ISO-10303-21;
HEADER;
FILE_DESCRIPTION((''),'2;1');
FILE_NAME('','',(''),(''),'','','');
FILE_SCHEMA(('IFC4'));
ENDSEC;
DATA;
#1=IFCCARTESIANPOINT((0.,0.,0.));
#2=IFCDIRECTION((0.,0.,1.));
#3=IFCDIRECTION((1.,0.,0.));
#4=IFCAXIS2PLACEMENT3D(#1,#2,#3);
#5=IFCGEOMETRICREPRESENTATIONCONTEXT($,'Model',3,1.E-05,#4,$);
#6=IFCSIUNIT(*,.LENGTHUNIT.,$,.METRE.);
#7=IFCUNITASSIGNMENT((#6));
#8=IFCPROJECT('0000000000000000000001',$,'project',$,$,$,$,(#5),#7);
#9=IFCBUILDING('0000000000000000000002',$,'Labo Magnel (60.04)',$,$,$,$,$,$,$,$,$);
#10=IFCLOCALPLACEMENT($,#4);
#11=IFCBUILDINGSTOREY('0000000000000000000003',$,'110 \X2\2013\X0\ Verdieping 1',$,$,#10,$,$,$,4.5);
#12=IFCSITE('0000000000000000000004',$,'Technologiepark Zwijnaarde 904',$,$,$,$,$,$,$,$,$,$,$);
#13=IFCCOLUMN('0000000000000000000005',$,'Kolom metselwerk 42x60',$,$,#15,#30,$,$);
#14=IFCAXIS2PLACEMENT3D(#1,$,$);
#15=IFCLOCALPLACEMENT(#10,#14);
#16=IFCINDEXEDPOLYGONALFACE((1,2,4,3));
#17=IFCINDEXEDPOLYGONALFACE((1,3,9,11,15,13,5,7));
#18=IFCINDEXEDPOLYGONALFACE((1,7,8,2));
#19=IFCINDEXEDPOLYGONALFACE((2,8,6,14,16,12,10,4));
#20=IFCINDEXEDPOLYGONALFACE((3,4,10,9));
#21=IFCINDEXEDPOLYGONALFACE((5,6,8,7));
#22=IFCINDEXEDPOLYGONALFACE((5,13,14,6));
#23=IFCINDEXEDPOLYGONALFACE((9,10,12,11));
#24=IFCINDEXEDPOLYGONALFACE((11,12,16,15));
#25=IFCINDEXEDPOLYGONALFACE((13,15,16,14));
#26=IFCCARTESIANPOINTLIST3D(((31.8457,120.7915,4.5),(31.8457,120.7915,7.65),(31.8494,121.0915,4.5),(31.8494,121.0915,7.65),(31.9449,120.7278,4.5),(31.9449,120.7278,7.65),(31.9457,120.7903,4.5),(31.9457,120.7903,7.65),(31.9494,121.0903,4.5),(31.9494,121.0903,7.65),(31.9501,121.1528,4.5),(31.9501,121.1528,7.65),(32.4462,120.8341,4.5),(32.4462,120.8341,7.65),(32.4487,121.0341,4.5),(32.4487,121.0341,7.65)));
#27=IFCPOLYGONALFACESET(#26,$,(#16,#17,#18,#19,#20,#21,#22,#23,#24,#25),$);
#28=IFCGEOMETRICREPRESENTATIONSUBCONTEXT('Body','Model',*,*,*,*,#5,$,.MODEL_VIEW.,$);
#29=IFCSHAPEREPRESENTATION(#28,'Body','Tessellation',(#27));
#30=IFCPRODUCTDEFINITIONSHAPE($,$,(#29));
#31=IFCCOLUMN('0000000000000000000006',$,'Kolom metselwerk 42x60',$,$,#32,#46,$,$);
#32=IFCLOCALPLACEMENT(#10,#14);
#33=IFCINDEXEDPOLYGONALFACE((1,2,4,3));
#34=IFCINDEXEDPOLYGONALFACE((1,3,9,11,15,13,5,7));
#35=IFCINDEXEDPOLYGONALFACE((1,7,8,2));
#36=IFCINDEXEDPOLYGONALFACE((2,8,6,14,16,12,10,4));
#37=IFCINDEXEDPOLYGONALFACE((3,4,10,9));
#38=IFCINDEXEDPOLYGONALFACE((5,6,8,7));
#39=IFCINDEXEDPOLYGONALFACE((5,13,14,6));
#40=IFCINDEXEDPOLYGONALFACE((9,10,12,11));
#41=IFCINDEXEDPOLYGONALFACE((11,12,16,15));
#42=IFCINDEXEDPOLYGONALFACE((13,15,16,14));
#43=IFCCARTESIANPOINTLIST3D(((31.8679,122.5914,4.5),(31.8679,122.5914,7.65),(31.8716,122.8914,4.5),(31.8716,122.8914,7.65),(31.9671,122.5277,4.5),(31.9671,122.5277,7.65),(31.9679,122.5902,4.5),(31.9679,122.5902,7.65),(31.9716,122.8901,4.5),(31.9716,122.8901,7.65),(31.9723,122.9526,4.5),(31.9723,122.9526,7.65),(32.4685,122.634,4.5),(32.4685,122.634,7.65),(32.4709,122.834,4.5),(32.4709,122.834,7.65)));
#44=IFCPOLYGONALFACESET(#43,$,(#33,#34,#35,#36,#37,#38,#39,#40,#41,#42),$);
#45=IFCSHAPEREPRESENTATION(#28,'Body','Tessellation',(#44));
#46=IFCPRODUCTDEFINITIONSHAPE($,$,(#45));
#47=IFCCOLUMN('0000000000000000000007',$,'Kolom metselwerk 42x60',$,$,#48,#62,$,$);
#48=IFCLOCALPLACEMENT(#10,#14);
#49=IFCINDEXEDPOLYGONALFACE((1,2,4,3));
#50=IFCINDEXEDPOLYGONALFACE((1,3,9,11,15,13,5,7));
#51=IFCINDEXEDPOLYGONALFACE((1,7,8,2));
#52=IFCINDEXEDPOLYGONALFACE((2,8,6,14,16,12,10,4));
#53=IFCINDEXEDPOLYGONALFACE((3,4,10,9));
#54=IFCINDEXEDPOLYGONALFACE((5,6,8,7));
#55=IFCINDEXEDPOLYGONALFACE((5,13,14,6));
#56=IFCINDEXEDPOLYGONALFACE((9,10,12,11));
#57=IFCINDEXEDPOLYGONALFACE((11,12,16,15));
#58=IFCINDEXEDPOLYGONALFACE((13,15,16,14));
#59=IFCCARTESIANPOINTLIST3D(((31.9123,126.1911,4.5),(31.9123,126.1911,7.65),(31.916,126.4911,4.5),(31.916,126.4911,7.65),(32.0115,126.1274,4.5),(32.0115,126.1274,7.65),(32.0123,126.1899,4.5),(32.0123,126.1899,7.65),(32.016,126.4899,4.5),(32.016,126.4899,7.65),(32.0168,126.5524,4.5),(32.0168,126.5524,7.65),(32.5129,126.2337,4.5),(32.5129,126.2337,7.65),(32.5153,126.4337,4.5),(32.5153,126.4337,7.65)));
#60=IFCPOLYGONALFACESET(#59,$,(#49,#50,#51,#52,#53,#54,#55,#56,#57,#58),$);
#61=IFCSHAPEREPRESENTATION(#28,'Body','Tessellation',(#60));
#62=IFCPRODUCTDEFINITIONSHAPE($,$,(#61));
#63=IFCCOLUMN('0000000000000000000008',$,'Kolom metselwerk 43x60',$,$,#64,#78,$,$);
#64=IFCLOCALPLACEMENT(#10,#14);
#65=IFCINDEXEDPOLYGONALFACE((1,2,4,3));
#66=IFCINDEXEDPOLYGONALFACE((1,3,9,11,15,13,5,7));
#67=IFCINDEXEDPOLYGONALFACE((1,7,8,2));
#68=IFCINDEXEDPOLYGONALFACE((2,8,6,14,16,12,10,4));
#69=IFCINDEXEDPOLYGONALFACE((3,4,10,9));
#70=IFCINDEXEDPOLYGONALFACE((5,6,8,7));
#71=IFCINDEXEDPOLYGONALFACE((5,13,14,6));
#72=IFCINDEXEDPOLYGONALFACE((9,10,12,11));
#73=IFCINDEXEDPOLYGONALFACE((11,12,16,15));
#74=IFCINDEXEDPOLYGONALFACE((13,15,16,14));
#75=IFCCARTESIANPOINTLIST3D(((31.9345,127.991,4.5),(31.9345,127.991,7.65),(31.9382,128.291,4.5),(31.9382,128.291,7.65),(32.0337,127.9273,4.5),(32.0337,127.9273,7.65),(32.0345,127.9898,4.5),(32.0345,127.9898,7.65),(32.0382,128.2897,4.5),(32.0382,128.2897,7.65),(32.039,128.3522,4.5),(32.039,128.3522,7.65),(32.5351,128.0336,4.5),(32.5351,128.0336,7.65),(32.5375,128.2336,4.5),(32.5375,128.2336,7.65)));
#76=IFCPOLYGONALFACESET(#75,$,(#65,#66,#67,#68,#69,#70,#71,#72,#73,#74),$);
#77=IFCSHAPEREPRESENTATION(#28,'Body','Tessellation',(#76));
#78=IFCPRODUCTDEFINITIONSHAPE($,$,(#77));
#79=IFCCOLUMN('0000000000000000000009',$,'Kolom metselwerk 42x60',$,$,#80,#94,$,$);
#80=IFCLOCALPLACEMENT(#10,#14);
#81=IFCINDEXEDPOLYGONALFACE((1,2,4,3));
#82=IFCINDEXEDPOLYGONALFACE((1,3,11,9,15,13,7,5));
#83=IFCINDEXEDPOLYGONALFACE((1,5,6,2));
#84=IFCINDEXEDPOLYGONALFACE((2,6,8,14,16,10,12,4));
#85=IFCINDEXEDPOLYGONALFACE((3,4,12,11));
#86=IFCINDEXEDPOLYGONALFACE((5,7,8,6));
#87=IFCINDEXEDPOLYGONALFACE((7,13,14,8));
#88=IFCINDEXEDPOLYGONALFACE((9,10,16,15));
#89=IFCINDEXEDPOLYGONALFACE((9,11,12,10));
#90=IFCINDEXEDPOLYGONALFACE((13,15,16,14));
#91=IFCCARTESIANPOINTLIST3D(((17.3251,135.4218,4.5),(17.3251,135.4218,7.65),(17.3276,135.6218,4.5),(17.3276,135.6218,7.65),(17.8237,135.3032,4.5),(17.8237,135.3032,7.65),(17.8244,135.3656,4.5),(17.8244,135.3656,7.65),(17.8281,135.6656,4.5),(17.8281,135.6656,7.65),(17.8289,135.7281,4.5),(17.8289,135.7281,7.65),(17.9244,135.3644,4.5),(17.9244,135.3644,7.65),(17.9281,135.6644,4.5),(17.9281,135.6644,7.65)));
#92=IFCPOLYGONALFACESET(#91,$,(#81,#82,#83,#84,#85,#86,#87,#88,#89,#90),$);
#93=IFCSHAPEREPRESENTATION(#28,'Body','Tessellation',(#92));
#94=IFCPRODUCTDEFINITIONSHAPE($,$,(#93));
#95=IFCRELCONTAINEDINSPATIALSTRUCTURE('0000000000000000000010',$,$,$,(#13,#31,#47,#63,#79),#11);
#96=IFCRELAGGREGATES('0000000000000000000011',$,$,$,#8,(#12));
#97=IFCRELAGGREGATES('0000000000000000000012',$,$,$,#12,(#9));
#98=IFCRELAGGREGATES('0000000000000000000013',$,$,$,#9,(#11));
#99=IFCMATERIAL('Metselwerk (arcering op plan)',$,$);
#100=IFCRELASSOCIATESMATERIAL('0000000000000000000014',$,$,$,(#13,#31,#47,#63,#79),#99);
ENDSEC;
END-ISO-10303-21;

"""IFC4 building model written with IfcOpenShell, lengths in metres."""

from ifc_helpers import new_model, si_unit, frame, origin, origin_with_axes, place, context, subcontext, project, spatial, polyline, outline, extrude, material, element, save


model = new_model("IFC4")

# Units and contexts
model_context = context("Model", 3, precision=1e-05, world=origin_with_axes())
body_context = subcontext(model_context, "Body", "Model", "MODEL_VIEW")
ifc_project = project(units=[si_unit("LENGTHUNIT", "METRE")], contexts=[model_context])

# Site, building, storey
site = spatial("IfcSite", under=ifc_project, Name="Technologiepark Zwijnaarde 904")
building = spatial("IfcBuilding", under=site, Name="Labo Magnel (60.04)")
storey_placement = place(None, origin_with_axes())
storey = spatial("IfcBuildingStorey", under=building, at=storey_placement, Name="110 – Verdieping 1", Elevation=4.5)

# Columns
ifc_material_1 = material(Name="Metselwerk (arcering op plan)")
column_1_placement = place(storey_placement, frame((0.0, 0.0, 4.5), z_axis=(0.0, 0.0, 1.0), x_axis=(1.0, 0.0, 0.0)))
element("IfcColumn", 1, at=column_1_placement, inside=storey, material=ifc_material_1, Name="Kolom metselwerk 42x60", context=body_context, shape_type="SweptSolid", body=[
    extrude(outline(polyline([(32.4487, 121.0341), (31.9501, 121.1528), (31.9494, 121.0903), (31.8494, 121.0915), (31.8457, 120.7915), (31.9457, 120.7903), (31.9449, 120.7278), (32.4462, 120.8341), (32.4487, 121.0341)])), origin(), (0.0, 0.0, 1.0), 3.15),
])
column_2_placement = place(storey_placement, frame((0.0, 0.0, 4.5), z_axis=(0.0, 0.0, 1.0), x_axis=(1.0, 0.0, 0.0)))
element("IfcColumn", 2, at=column_2_placement, inside=storey, material=ifc_material_1, Name="Kolom metselwerk 42x60", context=body_context, shape_type="SweptSolid", body=[
    extrude(outline(polyline([(32.4709, 122.834), (31.9723, 122.9526), (31.9716, 122.8901), (31.8716, 122.8914), (31.8679, 122.5914), (31.9679, 122.5902), (31.9671, 122.5277), (32.4685, 122.634), (32.4709, 122.834)])), origin(), (0.0, 0.0, 1.0), 3.15),
])
column_3_placement = place(storey_placement, frame((0.0, 0.0, 4.5), z_axis=(0.0, 0.0, 1.0), x_axis=(1.0, 0.0, 0.0)))
element("IfcColumn", 3, at=column_3_placement, inside=storey, material=ifc_material_1, Name="Kolom metselwerk 42x60", context=body_context, shape_type="SweptSolid", body=[
    extrude(outline(polyline([(32.5153, 126.4337), (32.0168, 126.5524), (32.016, 126.4899), (31.916, 126.4911), (31.9123, 126.1911), (32.0123, 126.1899), (32.0115, 126.1274), (32.5129, 126.2337), (32.5153, 126.4337)])), origin(), (0.0, 0.0, 1.0), 3.15),
])
column_4_placement = place(storey_placement, frame((0.0, 0.0, 4.5), z_axis=(0.0, 0.0, 1.0), x_axis=(1.0, 0.0, 0.0)))
element("IfcColumn", 4, at=column_4_placement, inside=storey, material=ifc_material_1, Name="Kolom metselwerk 43x60", context=body_context, shape_type="SweptSolid", body=[
    extrude(outline(polyline([(32.5375, 128.2336), (32.039, 128.3522), (32.0382, 128.2897), (31.9382, 128.291), (31.9345, 127.991), (32.0345, 127.9898), (32.0337, 127.9273), (32.5351, 128.0336), (32.5375, 128.2336)])), origin(), (0.0, 0.0, 1.0), 3.15),
])
column_5_placement = place(storey_placement, frame((0.0, 0.0, 4.5), z_axis=(0.0, 0.0, 1.0), x_axis=(1.0, 0.0, 0.0)))
element("IfcColumn", 5, at=column_5_placement, inside=storey, material=ifc_material_1, Name="Kolom metselwerk 42x60", context=body_context, shape_type="SweptSolid", body=[
    extrude(outline(polyline([(17.9281, 135.6644), (17.8281, 135.6656), (17.8289, 135.7281), (17.3276, 135.6218), (17.3251, 135.4218), (17.8237, 135.3032), (17.8244, 135.3656), (17.9244, 135.3644), (17.9281, 135.6644)])), origin(), (0.0, 0.0, 1.0), 3.15),
])

save(model, "model.ifc")
